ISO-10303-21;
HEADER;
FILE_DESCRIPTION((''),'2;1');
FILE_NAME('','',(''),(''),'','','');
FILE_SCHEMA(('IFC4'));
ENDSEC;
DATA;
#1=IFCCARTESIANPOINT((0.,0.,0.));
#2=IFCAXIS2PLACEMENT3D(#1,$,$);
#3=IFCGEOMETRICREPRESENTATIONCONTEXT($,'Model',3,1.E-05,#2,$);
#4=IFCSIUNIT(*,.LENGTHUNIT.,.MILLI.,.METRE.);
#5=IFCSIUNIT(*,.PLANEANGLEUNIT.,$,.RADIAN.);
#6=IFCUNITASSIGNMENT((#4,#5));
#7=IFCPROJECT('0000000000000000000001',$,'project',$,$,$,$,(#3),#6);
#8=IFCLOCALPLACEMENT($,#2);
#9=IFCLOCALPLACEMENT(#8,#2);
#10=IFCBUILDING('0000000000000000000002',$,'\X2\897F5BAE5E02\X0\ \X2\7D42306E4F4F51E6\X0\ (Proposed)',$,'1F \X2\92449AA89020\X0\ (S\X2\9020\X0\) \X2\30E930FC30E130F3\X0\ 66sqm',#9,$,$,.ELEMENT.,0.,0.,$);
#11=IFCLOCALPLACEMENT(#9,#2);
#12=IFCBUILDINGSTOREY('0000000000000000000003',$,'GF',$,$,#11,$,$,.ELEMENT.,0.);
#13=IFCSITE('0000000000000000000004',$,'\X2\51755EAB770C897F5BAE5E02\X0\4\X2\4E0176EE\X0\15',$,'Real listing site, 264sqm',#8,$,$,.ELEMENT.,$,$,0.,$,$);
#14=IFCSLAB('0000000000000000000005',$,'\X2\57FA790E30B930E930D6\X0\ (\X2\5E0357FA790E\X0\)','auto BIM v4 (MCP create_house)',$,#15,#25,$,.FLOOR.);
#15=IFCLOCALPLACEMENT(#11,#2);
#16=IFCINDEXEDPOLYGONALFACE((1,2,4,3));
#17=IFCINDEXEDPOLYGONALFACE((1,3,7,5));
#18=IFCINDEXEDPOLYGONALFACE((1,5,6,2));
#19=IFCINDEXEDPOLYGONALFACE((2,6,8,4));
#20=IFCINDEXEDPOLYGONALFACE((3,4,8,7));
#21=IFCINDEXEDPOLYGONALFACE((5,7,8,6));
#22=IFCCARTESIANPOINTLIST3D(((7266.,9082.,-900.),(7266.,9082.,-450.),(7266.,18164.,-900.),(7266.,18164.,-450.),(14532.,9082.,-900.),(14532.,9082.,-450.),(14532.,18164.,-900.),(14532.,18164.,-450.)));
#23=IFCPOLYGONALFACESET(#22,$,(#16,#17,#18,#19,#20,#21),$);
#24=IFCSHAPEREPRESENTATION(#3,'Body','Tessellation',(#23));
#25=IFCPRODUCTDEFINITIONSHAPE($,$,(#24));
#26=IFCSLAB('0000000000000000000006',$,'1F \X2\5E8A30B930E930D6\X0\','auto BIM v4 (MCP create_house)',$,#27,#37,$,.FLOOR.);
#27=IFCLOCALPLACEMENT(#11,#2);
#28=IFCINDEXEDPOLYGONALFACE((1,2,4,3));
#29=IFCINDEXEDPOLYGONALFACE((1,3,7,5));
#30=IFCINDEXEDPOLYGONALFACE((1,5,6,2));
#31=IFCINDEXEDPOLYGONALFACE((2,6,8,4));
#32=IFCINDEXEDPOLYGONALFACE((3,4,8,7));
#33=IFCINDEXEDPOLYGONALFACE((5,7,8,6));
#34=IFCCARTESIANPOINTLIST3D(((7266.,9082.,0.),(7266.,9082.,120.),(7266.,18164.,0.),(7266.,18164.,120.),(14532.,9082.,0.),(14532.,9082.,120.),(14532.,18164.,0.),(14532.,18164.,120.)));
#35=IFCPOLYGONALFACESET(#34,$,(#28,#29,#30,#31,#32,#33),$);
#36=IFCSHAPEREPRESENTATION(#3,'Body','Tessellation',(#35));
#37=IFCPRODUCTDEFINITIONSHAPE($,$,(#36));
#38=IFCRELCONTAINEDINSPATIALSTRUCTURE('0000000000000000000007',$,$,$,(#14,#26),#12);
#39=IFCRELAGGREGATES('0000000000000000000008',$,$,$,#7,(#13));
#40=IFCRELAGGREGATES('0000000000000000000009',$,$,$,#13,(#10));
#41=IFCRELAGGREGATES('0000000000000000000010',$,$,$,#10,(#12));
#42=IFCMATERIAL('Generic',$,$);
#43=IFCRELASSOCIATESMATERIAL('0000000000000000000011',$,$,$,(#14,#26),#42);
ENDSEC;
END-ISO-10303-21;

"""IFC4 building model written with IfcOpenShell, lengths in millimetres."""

from ifc_helpers import new_model, si_unit, frame, frame_2d, origin, place, context, project, spatial, rectangle, extrude, material, element, save


model = new_model("IFC4")

# Units and contexts
model_context = context("Model", 3, precision=1e-05, world=origin())
ifc_project = project(units=[si_unit("LENGTHUNIT", "METRE", prefix="MILLI"), si_unit("PLANEANGLEUNIT", "RADIAN")], contexts=[model_context])

# Site, building, storey
site_placement = place(None, origin())
site = spatial("IfcSite", under=ifc_project, at=site_placement, Name="兵庫県西宮市4丁目15", ObjectType="Real listing site, 264sqm", CompositionType="ELEMENT", RefElevation=0.0)
building_placement = place(site_placement, origin())
building = spatial("IfcBuilding", under=site, at=building_placement, Name="西宮市 終の住処 (Proposed)", ObjectType="1F 鉄骨造 (S造) ラーメン 66sqm", CompositionType="ELEMENT", ElevationOfRefHeight=0.0, ElevationOfTerrain=0.0)
storey_placement = place(building_placement, origin())
storey = spatial("IfcBuildingStorey", under=building, at=storey_placement, Name="GF", CompositionType="ELEMENT", Elevation=0.0)

# Slabs
ifc_material = material(Name="Generic")
slab_1_placement = place(storey_placement, frame((3633.0, 4541.0, -450.0)))
element("IfcSlab", 1, at=slab_1_placement, inside=storey, material=ifc_material, Name="基礎スラブ (布基礎)", Description="auto BIM v4 (MCP create_house)", PredefinedType="FLOOR", context=model_context, shape_type="SweptSolid", body=[
    extrude(rectangle(XDim=7266.0, YDim=9082.0, at=frame_2d((3633.0, 4541.0))), frame((3633.0, 4541.0, -450.0)), (0.0, 0.0, 1.0), 450.0),
])
slab_2_placement = place(storey_placement, frame((3633.0, 4541.0, 0.0)))
element("IfcSlab", 2, at=slab_2_placement, inside=storey, material=ifc_material, Name="1F 床スラブ", Description="auto BIM v4 (MCP create_house)", PredefinedType="FLOOR", context=model_context, shape_type="SweptSolid", body=[
    extrude(rectangle(XDim=7266.0, YDim=9082.0, at=frame_2d((3633.0, 4541.0))), frame((3633.0, 4541.0, 0.0)), (0.0, 0.0, 1.0), 120.0),
])

save(model, "model.ifc")
